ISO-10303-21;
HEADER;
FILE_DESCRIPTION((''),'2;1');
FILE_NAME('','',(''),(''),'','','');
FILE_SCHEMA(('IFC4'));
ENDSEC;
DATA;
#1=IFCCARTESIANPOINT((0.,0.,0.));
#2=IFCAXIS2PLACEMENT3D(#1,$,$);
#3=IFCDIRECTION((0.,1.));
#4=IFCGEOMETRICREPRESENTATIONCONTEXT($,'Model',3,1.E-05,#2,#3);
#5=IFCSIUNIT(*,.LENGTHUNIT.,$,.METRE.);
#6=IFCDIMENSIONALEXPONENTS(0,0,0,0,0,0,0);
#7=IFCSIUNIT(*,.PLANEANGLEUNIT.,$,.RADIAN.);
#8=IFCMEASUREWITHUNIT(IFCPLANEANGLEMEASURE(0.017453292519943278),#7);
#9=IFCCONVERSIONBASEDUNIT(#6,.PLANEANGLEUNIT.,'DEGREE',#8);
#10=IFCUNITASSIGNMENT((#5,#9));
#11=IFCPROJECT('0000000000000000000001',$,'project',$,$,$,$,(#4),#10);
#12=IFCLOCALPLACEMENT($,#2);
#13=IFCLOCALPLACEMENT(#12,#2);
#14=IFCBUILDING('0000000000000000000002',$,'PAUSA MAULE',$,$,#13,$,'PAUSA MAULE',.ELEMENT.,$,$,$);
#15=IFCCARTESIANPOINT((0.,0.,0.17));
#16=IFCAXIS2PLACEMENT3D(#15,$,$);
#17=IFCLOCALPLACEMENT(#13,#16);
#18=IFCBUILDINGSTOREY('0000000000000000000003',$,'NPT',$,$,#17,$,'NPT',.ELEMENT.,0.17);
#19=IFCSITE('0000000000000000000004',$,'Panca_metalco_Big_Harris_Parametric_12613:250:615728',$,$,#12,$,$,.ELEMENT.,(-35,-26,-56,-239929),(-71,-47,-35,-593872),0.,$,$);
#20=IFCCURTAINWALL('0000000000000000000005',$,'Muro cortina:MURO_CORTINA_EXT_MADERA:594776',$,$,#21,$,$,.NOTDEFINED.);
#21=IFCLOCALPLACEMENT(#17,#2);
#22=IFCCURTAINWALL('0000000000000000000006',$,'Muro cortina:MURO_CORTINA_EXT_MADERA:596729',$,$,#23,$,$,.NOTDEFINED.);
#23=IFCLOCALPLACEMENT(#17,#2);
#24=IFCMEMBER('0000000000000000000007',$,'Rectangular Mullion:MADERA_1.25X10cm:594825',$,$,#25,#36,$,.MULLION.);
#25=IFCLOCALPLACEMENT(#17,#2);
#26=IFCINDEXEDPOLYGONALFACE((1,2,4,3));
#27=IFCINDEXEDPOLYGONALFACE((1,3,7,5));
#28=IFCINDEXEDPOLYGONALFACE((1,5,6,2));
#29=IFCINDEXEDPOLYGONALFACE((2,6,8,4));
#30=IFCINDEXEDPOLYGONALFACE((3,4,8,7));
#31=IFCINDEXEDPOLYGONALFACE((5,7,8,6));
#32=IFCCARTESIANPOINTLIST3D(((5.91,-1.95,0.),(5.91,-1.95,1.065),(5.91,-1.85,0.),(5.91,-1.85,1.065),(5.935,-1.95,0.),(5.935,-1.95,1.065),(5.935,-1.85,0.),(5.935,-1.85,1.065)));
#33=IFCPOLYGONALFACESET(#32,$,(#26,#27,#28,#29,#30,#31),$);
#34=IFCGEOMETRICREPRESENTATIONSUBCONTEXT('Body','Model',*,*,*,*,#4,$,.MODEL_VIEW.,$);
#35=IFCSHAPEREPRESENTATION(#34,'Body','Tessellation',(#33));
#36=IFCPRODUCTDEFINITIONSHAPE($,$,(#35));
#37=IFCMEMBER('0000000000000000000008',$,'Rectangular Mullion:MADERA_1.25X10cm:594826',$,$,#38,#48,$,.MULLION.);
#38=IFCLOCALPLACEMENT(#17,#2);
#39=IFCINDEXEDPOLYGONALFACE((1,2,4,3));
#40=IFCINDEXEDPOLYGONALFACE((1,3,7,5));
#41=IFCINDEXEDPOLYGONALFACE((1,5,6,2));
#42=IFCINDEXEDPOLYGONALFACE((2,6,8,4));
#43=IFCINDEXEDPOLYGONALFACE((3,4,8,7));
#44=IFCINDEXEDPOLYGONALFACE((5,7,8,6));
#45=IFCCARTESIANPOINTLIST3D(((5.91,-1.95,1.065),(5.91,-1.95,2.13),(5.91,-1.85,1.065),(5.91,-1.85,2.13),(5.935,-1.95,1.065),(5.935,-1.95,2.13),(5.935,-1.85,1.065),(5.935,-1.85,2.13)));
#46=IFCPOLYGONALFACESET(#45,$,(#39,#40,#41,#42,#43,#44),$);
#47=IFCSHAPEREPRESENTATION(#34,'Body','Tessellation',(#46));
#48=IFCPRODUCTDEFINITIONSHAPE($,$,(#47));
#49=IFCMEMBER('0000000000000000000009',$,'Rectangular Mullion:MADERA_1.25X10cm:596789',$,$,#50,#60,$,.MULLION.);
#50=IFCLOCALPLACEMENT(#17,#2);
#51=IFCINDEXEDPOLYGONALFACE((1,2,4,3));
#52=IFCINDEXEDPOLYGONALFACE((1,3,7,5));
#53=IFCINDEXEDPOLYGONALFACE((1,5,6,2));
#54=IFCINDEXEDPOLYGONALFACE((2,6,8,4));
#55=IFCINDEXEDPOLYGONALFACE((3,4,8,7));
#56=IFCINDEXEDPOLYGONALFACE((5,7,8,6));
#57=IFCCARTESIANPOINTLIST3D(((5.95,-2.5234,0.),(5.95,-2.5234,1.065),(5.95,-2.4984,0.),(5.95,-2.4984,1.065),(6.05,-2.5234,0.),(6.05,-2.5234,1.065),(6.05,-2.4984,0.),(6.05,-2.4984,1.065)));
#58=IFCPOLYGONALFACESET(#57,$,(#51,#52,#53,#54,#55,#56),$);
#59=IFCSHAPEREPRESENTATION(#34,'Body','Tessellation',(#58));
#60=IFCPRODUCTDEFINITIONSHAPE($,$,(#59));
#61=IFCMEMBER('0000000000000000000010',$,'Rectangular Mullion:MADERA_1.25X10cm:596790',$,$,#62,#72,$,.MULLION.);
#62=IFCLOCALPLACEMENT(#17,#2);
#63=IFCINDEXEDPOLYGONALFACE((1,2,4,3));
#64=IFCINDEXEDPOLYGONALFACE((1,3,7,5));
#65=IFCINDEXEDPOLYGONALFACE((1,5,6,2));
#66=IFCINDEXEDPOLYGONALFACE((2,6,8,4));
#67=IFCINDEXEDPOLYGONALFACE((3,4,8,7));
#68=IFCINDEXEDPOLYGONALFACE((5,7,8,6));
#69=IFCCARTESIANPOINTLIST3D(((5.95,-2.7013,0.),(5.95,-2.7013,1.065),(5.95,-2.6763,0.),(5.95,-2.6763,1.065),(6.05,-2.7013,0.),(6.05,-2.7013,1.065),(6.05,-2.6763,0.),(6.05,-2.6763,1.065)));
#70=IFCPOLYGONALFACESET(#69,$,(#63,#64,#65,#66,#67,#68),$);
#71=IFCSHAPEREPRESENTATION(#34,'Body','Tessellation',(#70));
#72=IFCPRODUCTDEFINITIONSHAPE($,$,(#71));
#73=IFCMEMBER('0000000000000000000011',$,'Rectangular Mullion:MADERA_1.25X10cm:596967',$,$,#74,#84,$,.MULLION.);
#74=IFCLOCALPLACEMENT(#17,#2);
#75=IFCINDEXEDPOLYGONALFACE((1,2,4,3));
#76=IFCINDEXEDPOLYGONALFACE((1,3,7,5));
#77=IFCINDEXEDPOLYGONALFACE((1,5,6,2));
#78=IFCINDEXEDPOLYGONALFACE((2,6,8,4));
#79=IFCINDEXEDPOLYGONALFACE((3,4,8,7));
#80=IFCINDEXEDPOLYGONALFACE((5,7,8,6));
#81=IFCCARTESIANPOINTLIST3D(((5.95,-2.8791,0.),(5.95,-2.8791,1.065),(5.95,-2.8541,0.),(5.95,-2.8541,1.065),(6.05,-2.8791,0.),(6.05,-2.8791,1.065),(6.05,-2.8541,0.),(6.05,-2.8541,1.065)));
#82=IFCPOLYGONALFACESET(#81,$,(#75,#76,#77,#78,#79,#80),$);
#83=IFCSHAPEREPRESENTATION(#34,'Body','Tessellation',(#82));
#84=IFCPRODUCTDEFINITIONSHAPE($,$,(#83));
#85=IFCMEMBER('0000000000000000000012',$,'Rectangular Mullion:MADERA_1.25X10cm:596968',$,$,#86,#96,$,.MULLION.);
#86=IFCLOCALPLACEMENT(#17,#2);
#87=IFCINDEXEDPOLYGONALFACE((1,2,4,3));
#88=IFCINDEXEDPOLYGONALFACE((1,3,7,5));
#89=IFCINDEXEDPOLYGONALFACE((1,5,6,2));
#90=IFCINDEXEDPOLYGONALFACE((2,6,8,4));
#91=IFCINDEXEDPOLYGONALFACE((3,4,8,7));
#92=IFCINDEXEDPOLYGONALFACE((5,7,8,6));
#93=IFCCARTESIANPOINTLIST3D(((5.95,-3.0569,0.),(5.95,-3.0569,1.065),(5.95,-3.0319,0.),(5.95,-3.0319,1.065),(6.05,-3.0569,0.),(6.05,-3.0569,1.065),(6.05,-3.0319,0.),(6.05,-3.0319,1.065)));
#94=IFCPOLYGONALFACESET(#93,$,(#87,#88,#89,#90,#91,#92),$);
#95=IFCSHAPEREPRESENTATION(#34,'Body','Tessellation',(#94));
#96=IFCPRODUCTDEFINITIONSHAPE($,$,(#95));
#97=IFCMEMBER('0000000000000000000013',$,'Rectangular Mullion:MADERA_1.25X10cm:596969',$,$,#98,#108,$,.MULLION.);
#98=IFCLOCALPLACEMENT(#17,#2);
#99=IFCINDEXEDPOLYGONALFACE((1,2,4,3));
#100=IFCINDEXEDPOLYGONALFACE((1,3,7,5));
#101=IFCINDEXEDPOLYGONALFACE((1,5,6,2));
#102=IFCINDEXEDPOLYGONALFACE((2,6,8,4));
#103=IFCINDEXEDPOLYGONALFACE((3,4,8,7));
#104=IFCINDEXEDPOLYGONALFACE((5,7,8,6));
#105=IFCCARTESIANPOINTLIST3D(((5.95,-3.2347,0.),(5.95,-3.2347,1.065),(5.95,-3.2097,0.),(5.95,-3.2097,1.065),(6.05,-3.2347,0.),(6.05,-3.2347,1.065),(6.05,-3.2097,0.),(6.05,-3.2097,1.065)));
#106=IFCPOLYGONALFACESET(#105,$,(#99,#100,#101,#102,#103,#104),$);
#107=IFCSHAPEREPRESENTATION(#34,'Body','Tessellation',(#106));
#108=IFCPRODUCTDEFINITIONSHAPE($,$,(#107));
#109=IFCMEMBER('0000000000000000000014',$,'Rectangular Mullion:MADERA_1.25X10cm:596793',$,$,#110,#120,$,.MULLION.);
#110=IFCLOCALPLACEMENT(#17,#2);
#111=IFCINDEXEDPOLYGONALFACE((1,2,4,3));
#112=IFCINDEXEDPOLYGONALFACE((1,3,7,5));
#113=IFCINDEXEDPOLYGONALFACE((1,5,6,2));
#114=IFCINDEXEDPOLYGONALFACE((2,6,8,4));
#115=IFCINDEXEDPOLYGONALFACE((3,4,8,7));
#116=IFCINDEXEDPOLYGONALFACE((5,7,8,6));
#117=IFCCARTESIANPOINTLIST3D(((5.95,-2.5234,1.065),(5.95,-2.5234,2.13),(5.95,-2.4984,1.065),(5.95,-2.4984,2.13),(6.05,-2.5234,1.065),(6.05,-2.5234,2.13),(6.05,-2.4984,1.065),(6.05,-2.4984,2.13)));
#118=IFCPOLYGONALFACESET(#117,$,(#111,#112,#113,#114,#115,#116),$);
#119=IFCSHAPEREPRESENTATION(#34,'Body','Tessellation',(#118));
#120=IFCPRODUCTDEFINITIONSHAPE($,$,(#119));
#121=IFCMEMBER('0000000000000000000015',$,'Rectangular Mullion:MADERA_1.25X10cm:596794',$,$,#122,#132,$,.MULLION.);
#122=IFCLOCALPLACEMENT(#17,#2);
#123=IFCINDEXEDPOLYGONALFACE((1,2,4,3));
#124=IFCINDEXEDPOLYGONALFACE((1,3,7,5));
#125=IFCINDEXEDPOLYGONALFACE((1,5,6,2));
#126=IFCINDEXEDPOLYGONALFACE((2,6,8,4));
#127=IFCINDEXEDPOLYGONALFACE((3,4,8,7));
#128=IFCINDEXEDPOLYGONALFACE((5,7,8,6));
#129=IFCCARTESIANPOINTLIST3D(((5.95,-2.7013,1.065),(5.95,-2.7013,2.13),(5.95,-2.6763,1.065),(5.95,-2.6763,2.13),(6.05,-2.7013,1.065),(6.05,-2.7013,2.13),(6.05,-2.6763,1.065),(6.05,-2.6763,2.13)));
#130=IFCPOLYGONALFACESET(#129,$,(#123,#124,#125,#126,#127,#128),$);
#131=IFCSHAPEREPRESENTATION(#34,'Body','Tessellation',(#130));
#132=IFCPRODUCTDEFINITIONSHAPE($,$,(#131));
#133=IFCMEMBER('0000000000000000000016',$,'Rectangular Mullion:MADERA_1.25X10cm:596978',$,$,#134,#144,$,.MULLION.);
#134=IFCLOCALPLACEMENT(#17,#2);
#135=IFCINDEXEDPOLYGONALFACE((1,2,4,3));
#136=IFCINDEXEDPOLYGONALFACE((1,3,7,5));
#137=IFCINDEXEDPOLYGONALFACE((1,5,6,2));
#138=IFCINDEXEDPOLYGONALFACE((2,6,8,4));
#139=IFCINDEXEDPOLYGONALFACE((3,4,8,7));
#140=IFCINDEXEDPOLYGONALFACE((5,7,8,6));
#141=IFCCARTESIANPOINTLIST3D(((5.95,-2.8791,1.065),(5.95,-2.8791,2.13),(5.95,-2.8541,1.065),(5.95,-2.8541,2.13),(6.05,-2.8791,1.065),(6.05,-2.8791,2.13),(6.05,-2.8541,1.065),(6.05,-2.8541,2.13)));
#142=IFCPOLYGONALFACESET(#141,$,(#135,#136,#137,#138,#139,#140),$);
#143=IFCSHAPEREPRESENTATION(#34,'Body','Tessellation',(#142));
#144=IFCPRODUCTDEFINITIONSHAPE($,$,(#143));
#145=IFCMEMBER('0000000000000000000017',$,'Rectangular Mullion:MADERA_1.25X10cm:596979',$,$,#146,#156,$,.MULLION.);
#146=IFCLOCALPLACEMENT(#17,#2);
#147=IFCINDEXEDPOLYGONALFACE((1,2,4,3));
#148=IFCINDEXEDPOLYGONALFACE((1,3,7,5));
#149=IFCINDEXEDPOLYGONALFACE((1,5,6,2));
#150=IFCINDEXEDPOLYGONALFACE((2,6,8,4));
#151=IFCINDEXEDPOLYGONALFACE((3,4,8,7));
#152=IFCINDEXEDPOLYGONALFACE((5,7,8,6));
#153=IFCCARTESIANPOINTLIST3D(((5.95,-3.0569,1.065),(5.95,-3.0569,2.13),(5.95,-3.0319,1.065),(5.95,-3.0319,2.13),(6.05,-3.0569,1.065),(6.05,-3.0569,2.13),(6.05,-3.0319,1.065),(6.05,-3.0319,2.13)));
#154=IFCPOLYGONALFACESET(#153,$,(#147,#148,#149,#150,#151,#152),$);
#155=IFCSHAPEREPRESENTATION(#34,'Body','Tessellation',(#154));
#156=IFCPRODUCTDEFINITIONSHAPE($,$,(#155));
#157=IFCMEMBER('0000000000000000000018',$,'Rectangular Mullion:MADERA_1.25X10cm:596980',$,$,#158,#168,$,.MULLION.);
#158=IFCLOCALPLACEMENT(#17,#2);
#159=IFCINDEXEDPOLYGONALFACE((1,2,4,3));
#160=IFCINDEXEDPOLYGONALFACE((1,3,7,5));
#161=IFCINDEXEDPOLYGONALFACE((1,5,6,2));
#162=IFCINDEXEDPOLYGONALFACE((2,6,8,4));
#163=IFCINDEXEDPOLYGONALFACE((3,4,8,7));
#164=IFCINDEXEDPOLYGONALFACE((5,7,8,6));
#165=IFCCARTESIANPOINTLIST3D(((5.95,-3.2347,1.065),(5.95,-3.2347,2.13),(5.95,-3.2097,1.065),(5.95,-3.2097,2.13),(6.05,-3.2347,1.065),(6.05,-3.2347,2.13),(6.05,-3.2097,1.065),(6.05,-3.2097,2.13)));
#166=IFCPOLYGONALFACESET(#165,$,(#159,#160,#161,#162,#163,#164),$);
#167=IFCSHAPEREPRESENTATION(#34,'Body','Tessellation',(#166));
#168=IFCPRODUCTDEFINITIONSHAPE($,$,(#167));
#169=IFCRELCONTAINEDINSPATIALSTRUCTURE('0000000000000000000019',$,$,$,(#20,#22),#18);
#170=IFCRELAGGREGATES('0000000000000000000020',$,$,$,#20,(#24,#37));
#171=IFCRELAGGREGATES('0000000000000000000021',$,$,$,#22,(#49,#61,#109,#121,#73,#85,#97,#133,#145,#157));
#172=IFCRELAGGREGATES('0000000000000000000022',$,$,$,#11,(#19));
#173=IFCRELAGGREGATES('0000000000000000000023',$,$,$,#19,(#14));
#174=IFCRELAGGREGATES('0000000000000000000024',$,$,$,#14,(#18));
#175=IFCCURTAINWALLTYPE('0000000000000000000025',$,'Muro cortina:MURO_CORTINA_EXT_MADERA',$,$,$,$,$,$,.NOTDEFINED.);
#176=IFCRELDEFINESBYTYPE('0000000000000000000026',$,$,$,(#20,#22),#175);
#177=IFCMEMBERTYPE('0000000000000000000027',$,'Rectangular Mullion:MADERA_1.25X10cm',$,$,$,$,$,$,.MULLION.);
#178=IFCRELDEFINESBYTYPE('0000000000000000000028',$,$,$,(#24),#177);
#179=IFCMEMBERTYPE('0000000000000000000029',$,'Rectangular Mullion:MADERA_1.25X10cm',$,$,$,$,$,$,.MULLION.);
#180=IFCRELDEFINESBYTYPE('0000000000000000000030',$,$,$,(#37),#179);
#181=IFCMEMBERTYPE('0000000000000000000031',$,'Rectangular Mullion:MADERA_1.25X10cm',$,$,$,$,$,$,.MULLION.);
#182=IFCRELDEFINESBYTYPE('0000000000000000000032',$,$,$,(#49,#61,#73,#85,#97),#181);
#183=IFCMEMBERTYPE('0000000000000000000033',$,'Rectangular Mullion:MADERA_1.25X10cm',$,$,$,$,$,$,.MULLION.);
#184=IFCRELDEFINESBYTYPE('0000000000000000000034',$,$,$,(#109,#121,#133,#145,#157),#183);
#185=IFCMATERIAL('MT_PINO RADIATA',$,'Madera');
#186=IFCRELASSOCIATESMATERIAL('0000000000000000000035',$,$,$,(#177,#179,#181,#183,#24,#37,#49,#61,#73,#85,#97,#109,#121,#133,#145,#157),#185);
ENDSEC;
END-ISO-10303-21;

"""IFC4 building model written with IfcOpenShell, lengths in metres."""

from ifc_helpers import new_model, entity, si_unit, converted_unit, direction, frame, frame_2d, origin, origin_2d_with_axis, place, context, subcontext, project, spatial, rectangle, extrude, source, transform, mapped, material, material_profile, profile_set, profile_usage, type_object, type_shapes, element, aggregate, save


model = new_model("IFC4")

# Units and contexts
model_context = context("Model", 3, precision=1e-05, world=origin(), true_north=direction((0.0, 1.0)))
body_context = subcontext(model_context, "Body", "Model", "MODEL_VIEW")
ifc_project = project(units=[si_unit("LENGTHUNIT", "METRE"), converted_unit("PLANEANGLEUNIT", "DEGREE", entity("IfcPlaneAngleMeasure", 0.017453292519943278), si_unit("PLANEANGLEUNIT", "RADIAN"), dimensions=[0, 0, 0, 0, 0, 0, 0])], contexts=[model_context])

# Site, building, storey
site_placement = place(None, origin())
site = spatial("IfcSite", under=ifc_project, at=site_placement, Name="Panca_metalco_Big_Harris_Parametric_12613:250:615728", CompositionType="ELEMENT", RefLatitude=(-35, -26, -56, -239929), RefLongitude=(-71, -47, -35, -593872), RefElevation=0.0)
building_placement = place(site_placement, origin())
building = spatial("IfcBuilding", under=site, at=building_placement, Name="PAUSA MAULE", LongName="PAUSA MAULE", CompositionType="ELEMENT")
storey_placement = place(building_placement, frame((0.0, 0.0, 0.17)))
storey = spatial("IfcBuildingStorey", under=building, at=storey_placement, Name="NPT", LongName="NPT", CompositionType="ELEMENT", Elevation=0.17)

# Curtain wall
curtain_wall_type = type_object("IfcCurtainWallType", Name="Muro cortina:MURO_CORTINA_EXT_MADERA", PredefinedType="NOTDEFINED")
curtain_wall_1_placement = place(storey_placement, frame((0.0, 0.0, -0.17)))
curtain_wall_1 = element("IfcCurtainWall", 1, at=curtain_wall_1_placement, inside=storey, type_object=curtain_wall_type, Name="Muro cortina:MURO_CORTINA_EXT_MADERA:594776", PredefinedType="NOTDEFINED")
ifc_material = material(Name="MT_PINO RADIATA", Category="Madera")
ifc_material_profile = material_profile(ifc_material, rectangle(XDim=0.025, YDim=0.1, at=frame_2d((0.0, 0.0), x_axis=(1.0, 0.0))), Name="MADERA_1.25X10cm")
ifc_profile_set = profile_set([ifc_material_profile], Name="MADERA_1.25X10cm")
ifc_profile_usage = profile_usage(ifc_profile_set)

# Curtain wall
curtain_wall_2_placement = place(storey_placement, frame((0.0, 0.0, -0.17)))
curtain_wall_2 = element("IfcCurtainWall", 2, at=curtain_wall_2_placement, inside=storey, type_object=curtain_wall_type, Name="Muro cortina:MURO_CORTINA_EXT_MADERA:596729", PredefinedType="NOTDEFINED")

# Members
member_type_1 = type_object("IfcMemberType", Name="Rectangular Mullion:MADERA_1.25X10cm", PredefinedType="MULLION", material=ifc_profile_set)
shared_shape_1 = source(origin(), body_context, "Body", "SweptSolid", [
    extrude(rectangle(XDim=0.025, YDim=0.1, at=origin_2d_with_axis()), frame((-0.0125, 0.0, -1.065), z_axis=(0.0, 0.0, 1.0), x_axis=(-1.0, 0.0, 0.0)), (0.0, 0.0, 1.0), 1.065),
])
type_shapes(member_type_1, [shared_shape_1])
member_1_placement = place(curtain_wall_1_placement, frame((5.935, -1.9, 0.17), z_axis=(0.0, 0.0, -1.0), x_axis=(1.0, 0.0, 0.0)))
member_1 = element("IfcMember", 3, at=member_1_placement, type_object=member_type_1, material=ifc_profile_usage, Name="Rectangular Mullion:MADERA_1.25X10cm:594825", PredefinedType="MULLION", context=body_context, shape_type="MappedRepresentation", body=[
    mapped(shared_shape_1, transform((0.0, 0.0, 0.0), scale=1.0)),
])
member_type_2 = type_object("IfcMemberType", Name="Rectangular Mullion:MADERA_1.25X10cm", PredefinedType="MULLION", material=ifc_profile_set)
shared_shape_2 = source(origin(), body_context, "Body", "SweptSolid", [
    extrude(rectangle(XDim=0.025, YDim=0.1, at=origin_2d_with_axis()), frame((-0.0125, 0.0, -1.065), z_axis=(0.0, 0.0, 1.0), x_axis=(-1.0, 0.0, 0.0)), (0.0, 0.0, 1.0), 1.065),
])
type_shapes(member_type_2, [shared_shape_2])
member_2_placement = place(curtain_wall_1_placement, frame((5.935, -1.9, 1.235), z_axis=(0.0, 0.0, -1.0), x_axis=(1.0, 0.0, 0.0)))
member_2 = element("IfcMember", 4, at=member_2_placement, type_object=member_type_2, material=ifc_profile_usage, Name="Rectangular Mullion:MADERA_1.25X10cm:594826", PredefinedType="MULLION", context=body_context, shape_type="MappedRepresentation", body=[
    mapped(shared_shape_2, transform((0.0, 0.0, 0.0), scale=1.0)),
])
aggregate(curtain_wall_1, [member_1, member_2])
member_type_3 = type_object("IfcMemberType", Name="Rectangular Mullion:MADERA_1.25X10cm", PredefinedType="MULLION", material=ifc_profile_set)
shared_shape_3 = source(origin(), body_context, "Body", "SweptSolid", [
    extrude(rectangle(XDim=0.025, YDim=0.1, at=frame_2d((0.0, 0.0), x_axis=(1.0, 0.0))), frame((0.0, 0.0, -1.065), z_axis=(0.0, 0.0, 1.0), x_axis=(-1.0, 0.0, 0.0)), (0.0, 0.0, 1.0), 1.065),
])
type_shapes(member_type_3, [shared_shape_3])
member_3_placement = place(curtain_wall_2_placement, frame((6.0, -2.5109, 0.17), z_axis=(0.0, 0.0, -1.0), x_axis=(0.0, -1.0, 0.0)))
member_3 = element("IfcMember", 5, at=member_3_placement, type_object=member_type_3, material=ifc_profile_usage, Name="Rectangular Mullion:MADERA_1.25X10cm:596789", PredefinedType="MULLION", context=body_context, shape_type="MappedRepresentation", body=[
    mapped(shared_shape_3, transform((0.0, 0.0, 0.0), scale=1.0)),
])
member_4_placement = place(curtain_wall_2_placement, frame((6.0, -2.6888, 0.17), z_axis=(0.0, 0.0, -1.0), x_axis=(0.0, -1.0, 0.0)))
member_4 = element("IfcMember", 6, at=member_4_placement, type_object=member_type_3, material=ifc_profile_usage, Name="Rectangular Mullion:MADERA_1.25X10cm:596790", PredefinedType="MULLION", context=body_context, shape_type="MappedRepresentation", body=[
    mapped(shared_shape_3, transform((0.0, 0.0, 0.0), scale=1.0)),
])
member_5_placement = place(curtain_wall_2_placement, frame((6.0, -2.8666, 0.17), z_axis=(0.0, 0.0, -1.0), x_axis=(0.0, -1.0, 0.0)))
member_5 = element("IfcMember", 7, at=member_5_placement, type_object=member_type_3, material=ifc_profile_usage, Name="Rectangular Mullion:MADERA_1.25X10cm:596967", PredefinedType="MULLION", context=body_context, shape_type="MappedRepresentation", body=[
    mapped(shared_shape_3, transform((0.0, 0.0, 0.0), scale=1.0)),
])
member_6_placement = place(curtain_wall_2_placement, frame((6.0, -3.0444, 0.17), z_axis=(0.0, 0.0, -1.0), x_axis=(0.0, -1.0, 0.0)))
member_6 = element("IfcMember", 8, at=member_6_placement, type_object=member_type_3, material=ifc_profile_usage, Name="Rectangular Mullion:MADERA_1.25X10cm:596968", PredefinedType="MULLION", context=body_context, shape_type="MappedRepresentation", body=[
    mapped(shared_shape_3, transform((0.0, 0.0, 0.0), scale=1.0)),
])
member_7_placement = place(curtain_wall_2_placement, frame((6.0, -3.2222, 0.17), z_axis=(0.0, 0.0, -1.0), x_axis=(0.0, -1.0, 0.0)))
member_7 = element("IfcMember", 9, at=member_7_placement, type_object=member_type_3, material=ifc_profile_usage, Name="Rectangular Mullion:MADERA_1.25X10cm:596969", PredefinedType="MULLION", context=body_context, shape_type="MappedRepresentation", body=[
    mapped(shared_shape_3, transform((0.0, 0.0, 0.0), scale=1.0)),
])
member_type_4 = type_object("IfcMemberType", Name="Rectangular Mullion:MADERA_1.25X10cm", PredefinedType="MULLION", material=ifc_profile_set)
shared_shape_4 = source(origin(), body_context, "Body", "SweptSolid", [
    extrude(rectangle(XDim=0.025, YDim=0.1, at=frame_2d((0.0, 0.0), x_axis=(1.0, 0.0))), frame((0.0, 0.0, -1.065), z_axis=(0.0, 0.0, 1.0), x_axis=(-1.0, 0.0, 0.0)), (0.0, 0.0, 1.0), 1.065),
])
type_shapes(member_type_4, [shared_shape_4])
member_8_placement = place(curtain_wall_2_placement, frame((6.0, -2.5109, 1.235), z_axis=(0.0, 0.0, -1.0), x_axis=(0.0, -1.0, 0.0)))
member_8 = element("IfcMember", 10, at=member_8_placement, type_object=member_type_4, material=ifc_profile_usage, Name="Rectangular Mullion:MADERA_1.25X10cm:596793", PredefinedType="MULLION", context=body_context, shape_type="MappedRepresentation", body=[
    mapped(shared_shape_4, transform((0.0, 0.0, 0.0), scale=1.0)),
])
member_9_placement = place(curtain_wall_2_placement, frame((6.0, -2.6888, 1.235), z_axis=(0.0, 0.0, -1.0), x_axis=(0.0, -1.0, 0.0)))
member_9 = element("IfcMember", 11, at=member_9_placement, type_object=member_type_4, material=ifc_profile_usage, Name="Rectangular Mullion:MADERA_1.25X10cm:596794", PredefinedType="MULLION", context=body_context, shape_type="MappedRepresentation", body=[
    mapped(shared_shape_4, transform((0.0, 0.0, 0.0), scale=1.0)),
])
member_10_placement = place(curtain_wall_2_placement, frame((6.0, -2.8666, 1.235), z_axis=(0.0, 0.0, -1.0), x_axis=(0.0, -1.0, 0.0)))
member_10 = element("IfcMember", 12, at=member_10_placement, type_object=member_type_4, material=ifc_profile_usage, Name="Rectangular Mullion:MADERA_1.25X10cm:596978", PredefinedType="MULLION", context=body_context, shape_type="MappedRepresentation", body=[
    mapped(shared_shape_4, transform((0.0, 0.0, 0.0), scale=1.0)),
])
member_11_placement = place(curtain_wall_2_placement, frame((6.0, -3.0444, 1.235), z_axis=(0.0, 0.0, -1.0), x_axis=(0.0, -1.0, 0.0)))
member_11 = element("IfcMember", 13, at=member_11_placement, type_object=member_type_4, material=ifc_profile_usage, Name="Rectangular Mullion:MADERA_1.25X10cm:596979", PredefinedType="MULLION", context=body_context, shape_type="MappedRepresentation", body=[
    mapped(shared_shape_4, transform((0.0, 0.0, 0.0), scale=1.0)),
])
member_12_placement = place(curtain_wall_2_placement, frame((6.0, -3.2222, 1.235), z_axis=(0.0, 0.0, -1.0), x_axis=(0.0, -1.0, 0.0)))
member_12 = element("IfcMember", 14, at=member_12_placement, type_object=member_type_4, material=ifc_profile_usage, Name="Rectangular Mullion:MADERA_1.25X10cm:596980", PredefinedType="MULLION", context=body_context, shape_type="MappedRepresentation", body=[
    mapped(shared_shape_4, transform((0.0, 0.0, 0.0), scale=1.0)),
])
aggregate(curtain_wall_2, [member_3, member_4, member_8, member_9, member_5, member_6, member_7, member_10, member_11, member_12])

save(model, "model.ifc")
